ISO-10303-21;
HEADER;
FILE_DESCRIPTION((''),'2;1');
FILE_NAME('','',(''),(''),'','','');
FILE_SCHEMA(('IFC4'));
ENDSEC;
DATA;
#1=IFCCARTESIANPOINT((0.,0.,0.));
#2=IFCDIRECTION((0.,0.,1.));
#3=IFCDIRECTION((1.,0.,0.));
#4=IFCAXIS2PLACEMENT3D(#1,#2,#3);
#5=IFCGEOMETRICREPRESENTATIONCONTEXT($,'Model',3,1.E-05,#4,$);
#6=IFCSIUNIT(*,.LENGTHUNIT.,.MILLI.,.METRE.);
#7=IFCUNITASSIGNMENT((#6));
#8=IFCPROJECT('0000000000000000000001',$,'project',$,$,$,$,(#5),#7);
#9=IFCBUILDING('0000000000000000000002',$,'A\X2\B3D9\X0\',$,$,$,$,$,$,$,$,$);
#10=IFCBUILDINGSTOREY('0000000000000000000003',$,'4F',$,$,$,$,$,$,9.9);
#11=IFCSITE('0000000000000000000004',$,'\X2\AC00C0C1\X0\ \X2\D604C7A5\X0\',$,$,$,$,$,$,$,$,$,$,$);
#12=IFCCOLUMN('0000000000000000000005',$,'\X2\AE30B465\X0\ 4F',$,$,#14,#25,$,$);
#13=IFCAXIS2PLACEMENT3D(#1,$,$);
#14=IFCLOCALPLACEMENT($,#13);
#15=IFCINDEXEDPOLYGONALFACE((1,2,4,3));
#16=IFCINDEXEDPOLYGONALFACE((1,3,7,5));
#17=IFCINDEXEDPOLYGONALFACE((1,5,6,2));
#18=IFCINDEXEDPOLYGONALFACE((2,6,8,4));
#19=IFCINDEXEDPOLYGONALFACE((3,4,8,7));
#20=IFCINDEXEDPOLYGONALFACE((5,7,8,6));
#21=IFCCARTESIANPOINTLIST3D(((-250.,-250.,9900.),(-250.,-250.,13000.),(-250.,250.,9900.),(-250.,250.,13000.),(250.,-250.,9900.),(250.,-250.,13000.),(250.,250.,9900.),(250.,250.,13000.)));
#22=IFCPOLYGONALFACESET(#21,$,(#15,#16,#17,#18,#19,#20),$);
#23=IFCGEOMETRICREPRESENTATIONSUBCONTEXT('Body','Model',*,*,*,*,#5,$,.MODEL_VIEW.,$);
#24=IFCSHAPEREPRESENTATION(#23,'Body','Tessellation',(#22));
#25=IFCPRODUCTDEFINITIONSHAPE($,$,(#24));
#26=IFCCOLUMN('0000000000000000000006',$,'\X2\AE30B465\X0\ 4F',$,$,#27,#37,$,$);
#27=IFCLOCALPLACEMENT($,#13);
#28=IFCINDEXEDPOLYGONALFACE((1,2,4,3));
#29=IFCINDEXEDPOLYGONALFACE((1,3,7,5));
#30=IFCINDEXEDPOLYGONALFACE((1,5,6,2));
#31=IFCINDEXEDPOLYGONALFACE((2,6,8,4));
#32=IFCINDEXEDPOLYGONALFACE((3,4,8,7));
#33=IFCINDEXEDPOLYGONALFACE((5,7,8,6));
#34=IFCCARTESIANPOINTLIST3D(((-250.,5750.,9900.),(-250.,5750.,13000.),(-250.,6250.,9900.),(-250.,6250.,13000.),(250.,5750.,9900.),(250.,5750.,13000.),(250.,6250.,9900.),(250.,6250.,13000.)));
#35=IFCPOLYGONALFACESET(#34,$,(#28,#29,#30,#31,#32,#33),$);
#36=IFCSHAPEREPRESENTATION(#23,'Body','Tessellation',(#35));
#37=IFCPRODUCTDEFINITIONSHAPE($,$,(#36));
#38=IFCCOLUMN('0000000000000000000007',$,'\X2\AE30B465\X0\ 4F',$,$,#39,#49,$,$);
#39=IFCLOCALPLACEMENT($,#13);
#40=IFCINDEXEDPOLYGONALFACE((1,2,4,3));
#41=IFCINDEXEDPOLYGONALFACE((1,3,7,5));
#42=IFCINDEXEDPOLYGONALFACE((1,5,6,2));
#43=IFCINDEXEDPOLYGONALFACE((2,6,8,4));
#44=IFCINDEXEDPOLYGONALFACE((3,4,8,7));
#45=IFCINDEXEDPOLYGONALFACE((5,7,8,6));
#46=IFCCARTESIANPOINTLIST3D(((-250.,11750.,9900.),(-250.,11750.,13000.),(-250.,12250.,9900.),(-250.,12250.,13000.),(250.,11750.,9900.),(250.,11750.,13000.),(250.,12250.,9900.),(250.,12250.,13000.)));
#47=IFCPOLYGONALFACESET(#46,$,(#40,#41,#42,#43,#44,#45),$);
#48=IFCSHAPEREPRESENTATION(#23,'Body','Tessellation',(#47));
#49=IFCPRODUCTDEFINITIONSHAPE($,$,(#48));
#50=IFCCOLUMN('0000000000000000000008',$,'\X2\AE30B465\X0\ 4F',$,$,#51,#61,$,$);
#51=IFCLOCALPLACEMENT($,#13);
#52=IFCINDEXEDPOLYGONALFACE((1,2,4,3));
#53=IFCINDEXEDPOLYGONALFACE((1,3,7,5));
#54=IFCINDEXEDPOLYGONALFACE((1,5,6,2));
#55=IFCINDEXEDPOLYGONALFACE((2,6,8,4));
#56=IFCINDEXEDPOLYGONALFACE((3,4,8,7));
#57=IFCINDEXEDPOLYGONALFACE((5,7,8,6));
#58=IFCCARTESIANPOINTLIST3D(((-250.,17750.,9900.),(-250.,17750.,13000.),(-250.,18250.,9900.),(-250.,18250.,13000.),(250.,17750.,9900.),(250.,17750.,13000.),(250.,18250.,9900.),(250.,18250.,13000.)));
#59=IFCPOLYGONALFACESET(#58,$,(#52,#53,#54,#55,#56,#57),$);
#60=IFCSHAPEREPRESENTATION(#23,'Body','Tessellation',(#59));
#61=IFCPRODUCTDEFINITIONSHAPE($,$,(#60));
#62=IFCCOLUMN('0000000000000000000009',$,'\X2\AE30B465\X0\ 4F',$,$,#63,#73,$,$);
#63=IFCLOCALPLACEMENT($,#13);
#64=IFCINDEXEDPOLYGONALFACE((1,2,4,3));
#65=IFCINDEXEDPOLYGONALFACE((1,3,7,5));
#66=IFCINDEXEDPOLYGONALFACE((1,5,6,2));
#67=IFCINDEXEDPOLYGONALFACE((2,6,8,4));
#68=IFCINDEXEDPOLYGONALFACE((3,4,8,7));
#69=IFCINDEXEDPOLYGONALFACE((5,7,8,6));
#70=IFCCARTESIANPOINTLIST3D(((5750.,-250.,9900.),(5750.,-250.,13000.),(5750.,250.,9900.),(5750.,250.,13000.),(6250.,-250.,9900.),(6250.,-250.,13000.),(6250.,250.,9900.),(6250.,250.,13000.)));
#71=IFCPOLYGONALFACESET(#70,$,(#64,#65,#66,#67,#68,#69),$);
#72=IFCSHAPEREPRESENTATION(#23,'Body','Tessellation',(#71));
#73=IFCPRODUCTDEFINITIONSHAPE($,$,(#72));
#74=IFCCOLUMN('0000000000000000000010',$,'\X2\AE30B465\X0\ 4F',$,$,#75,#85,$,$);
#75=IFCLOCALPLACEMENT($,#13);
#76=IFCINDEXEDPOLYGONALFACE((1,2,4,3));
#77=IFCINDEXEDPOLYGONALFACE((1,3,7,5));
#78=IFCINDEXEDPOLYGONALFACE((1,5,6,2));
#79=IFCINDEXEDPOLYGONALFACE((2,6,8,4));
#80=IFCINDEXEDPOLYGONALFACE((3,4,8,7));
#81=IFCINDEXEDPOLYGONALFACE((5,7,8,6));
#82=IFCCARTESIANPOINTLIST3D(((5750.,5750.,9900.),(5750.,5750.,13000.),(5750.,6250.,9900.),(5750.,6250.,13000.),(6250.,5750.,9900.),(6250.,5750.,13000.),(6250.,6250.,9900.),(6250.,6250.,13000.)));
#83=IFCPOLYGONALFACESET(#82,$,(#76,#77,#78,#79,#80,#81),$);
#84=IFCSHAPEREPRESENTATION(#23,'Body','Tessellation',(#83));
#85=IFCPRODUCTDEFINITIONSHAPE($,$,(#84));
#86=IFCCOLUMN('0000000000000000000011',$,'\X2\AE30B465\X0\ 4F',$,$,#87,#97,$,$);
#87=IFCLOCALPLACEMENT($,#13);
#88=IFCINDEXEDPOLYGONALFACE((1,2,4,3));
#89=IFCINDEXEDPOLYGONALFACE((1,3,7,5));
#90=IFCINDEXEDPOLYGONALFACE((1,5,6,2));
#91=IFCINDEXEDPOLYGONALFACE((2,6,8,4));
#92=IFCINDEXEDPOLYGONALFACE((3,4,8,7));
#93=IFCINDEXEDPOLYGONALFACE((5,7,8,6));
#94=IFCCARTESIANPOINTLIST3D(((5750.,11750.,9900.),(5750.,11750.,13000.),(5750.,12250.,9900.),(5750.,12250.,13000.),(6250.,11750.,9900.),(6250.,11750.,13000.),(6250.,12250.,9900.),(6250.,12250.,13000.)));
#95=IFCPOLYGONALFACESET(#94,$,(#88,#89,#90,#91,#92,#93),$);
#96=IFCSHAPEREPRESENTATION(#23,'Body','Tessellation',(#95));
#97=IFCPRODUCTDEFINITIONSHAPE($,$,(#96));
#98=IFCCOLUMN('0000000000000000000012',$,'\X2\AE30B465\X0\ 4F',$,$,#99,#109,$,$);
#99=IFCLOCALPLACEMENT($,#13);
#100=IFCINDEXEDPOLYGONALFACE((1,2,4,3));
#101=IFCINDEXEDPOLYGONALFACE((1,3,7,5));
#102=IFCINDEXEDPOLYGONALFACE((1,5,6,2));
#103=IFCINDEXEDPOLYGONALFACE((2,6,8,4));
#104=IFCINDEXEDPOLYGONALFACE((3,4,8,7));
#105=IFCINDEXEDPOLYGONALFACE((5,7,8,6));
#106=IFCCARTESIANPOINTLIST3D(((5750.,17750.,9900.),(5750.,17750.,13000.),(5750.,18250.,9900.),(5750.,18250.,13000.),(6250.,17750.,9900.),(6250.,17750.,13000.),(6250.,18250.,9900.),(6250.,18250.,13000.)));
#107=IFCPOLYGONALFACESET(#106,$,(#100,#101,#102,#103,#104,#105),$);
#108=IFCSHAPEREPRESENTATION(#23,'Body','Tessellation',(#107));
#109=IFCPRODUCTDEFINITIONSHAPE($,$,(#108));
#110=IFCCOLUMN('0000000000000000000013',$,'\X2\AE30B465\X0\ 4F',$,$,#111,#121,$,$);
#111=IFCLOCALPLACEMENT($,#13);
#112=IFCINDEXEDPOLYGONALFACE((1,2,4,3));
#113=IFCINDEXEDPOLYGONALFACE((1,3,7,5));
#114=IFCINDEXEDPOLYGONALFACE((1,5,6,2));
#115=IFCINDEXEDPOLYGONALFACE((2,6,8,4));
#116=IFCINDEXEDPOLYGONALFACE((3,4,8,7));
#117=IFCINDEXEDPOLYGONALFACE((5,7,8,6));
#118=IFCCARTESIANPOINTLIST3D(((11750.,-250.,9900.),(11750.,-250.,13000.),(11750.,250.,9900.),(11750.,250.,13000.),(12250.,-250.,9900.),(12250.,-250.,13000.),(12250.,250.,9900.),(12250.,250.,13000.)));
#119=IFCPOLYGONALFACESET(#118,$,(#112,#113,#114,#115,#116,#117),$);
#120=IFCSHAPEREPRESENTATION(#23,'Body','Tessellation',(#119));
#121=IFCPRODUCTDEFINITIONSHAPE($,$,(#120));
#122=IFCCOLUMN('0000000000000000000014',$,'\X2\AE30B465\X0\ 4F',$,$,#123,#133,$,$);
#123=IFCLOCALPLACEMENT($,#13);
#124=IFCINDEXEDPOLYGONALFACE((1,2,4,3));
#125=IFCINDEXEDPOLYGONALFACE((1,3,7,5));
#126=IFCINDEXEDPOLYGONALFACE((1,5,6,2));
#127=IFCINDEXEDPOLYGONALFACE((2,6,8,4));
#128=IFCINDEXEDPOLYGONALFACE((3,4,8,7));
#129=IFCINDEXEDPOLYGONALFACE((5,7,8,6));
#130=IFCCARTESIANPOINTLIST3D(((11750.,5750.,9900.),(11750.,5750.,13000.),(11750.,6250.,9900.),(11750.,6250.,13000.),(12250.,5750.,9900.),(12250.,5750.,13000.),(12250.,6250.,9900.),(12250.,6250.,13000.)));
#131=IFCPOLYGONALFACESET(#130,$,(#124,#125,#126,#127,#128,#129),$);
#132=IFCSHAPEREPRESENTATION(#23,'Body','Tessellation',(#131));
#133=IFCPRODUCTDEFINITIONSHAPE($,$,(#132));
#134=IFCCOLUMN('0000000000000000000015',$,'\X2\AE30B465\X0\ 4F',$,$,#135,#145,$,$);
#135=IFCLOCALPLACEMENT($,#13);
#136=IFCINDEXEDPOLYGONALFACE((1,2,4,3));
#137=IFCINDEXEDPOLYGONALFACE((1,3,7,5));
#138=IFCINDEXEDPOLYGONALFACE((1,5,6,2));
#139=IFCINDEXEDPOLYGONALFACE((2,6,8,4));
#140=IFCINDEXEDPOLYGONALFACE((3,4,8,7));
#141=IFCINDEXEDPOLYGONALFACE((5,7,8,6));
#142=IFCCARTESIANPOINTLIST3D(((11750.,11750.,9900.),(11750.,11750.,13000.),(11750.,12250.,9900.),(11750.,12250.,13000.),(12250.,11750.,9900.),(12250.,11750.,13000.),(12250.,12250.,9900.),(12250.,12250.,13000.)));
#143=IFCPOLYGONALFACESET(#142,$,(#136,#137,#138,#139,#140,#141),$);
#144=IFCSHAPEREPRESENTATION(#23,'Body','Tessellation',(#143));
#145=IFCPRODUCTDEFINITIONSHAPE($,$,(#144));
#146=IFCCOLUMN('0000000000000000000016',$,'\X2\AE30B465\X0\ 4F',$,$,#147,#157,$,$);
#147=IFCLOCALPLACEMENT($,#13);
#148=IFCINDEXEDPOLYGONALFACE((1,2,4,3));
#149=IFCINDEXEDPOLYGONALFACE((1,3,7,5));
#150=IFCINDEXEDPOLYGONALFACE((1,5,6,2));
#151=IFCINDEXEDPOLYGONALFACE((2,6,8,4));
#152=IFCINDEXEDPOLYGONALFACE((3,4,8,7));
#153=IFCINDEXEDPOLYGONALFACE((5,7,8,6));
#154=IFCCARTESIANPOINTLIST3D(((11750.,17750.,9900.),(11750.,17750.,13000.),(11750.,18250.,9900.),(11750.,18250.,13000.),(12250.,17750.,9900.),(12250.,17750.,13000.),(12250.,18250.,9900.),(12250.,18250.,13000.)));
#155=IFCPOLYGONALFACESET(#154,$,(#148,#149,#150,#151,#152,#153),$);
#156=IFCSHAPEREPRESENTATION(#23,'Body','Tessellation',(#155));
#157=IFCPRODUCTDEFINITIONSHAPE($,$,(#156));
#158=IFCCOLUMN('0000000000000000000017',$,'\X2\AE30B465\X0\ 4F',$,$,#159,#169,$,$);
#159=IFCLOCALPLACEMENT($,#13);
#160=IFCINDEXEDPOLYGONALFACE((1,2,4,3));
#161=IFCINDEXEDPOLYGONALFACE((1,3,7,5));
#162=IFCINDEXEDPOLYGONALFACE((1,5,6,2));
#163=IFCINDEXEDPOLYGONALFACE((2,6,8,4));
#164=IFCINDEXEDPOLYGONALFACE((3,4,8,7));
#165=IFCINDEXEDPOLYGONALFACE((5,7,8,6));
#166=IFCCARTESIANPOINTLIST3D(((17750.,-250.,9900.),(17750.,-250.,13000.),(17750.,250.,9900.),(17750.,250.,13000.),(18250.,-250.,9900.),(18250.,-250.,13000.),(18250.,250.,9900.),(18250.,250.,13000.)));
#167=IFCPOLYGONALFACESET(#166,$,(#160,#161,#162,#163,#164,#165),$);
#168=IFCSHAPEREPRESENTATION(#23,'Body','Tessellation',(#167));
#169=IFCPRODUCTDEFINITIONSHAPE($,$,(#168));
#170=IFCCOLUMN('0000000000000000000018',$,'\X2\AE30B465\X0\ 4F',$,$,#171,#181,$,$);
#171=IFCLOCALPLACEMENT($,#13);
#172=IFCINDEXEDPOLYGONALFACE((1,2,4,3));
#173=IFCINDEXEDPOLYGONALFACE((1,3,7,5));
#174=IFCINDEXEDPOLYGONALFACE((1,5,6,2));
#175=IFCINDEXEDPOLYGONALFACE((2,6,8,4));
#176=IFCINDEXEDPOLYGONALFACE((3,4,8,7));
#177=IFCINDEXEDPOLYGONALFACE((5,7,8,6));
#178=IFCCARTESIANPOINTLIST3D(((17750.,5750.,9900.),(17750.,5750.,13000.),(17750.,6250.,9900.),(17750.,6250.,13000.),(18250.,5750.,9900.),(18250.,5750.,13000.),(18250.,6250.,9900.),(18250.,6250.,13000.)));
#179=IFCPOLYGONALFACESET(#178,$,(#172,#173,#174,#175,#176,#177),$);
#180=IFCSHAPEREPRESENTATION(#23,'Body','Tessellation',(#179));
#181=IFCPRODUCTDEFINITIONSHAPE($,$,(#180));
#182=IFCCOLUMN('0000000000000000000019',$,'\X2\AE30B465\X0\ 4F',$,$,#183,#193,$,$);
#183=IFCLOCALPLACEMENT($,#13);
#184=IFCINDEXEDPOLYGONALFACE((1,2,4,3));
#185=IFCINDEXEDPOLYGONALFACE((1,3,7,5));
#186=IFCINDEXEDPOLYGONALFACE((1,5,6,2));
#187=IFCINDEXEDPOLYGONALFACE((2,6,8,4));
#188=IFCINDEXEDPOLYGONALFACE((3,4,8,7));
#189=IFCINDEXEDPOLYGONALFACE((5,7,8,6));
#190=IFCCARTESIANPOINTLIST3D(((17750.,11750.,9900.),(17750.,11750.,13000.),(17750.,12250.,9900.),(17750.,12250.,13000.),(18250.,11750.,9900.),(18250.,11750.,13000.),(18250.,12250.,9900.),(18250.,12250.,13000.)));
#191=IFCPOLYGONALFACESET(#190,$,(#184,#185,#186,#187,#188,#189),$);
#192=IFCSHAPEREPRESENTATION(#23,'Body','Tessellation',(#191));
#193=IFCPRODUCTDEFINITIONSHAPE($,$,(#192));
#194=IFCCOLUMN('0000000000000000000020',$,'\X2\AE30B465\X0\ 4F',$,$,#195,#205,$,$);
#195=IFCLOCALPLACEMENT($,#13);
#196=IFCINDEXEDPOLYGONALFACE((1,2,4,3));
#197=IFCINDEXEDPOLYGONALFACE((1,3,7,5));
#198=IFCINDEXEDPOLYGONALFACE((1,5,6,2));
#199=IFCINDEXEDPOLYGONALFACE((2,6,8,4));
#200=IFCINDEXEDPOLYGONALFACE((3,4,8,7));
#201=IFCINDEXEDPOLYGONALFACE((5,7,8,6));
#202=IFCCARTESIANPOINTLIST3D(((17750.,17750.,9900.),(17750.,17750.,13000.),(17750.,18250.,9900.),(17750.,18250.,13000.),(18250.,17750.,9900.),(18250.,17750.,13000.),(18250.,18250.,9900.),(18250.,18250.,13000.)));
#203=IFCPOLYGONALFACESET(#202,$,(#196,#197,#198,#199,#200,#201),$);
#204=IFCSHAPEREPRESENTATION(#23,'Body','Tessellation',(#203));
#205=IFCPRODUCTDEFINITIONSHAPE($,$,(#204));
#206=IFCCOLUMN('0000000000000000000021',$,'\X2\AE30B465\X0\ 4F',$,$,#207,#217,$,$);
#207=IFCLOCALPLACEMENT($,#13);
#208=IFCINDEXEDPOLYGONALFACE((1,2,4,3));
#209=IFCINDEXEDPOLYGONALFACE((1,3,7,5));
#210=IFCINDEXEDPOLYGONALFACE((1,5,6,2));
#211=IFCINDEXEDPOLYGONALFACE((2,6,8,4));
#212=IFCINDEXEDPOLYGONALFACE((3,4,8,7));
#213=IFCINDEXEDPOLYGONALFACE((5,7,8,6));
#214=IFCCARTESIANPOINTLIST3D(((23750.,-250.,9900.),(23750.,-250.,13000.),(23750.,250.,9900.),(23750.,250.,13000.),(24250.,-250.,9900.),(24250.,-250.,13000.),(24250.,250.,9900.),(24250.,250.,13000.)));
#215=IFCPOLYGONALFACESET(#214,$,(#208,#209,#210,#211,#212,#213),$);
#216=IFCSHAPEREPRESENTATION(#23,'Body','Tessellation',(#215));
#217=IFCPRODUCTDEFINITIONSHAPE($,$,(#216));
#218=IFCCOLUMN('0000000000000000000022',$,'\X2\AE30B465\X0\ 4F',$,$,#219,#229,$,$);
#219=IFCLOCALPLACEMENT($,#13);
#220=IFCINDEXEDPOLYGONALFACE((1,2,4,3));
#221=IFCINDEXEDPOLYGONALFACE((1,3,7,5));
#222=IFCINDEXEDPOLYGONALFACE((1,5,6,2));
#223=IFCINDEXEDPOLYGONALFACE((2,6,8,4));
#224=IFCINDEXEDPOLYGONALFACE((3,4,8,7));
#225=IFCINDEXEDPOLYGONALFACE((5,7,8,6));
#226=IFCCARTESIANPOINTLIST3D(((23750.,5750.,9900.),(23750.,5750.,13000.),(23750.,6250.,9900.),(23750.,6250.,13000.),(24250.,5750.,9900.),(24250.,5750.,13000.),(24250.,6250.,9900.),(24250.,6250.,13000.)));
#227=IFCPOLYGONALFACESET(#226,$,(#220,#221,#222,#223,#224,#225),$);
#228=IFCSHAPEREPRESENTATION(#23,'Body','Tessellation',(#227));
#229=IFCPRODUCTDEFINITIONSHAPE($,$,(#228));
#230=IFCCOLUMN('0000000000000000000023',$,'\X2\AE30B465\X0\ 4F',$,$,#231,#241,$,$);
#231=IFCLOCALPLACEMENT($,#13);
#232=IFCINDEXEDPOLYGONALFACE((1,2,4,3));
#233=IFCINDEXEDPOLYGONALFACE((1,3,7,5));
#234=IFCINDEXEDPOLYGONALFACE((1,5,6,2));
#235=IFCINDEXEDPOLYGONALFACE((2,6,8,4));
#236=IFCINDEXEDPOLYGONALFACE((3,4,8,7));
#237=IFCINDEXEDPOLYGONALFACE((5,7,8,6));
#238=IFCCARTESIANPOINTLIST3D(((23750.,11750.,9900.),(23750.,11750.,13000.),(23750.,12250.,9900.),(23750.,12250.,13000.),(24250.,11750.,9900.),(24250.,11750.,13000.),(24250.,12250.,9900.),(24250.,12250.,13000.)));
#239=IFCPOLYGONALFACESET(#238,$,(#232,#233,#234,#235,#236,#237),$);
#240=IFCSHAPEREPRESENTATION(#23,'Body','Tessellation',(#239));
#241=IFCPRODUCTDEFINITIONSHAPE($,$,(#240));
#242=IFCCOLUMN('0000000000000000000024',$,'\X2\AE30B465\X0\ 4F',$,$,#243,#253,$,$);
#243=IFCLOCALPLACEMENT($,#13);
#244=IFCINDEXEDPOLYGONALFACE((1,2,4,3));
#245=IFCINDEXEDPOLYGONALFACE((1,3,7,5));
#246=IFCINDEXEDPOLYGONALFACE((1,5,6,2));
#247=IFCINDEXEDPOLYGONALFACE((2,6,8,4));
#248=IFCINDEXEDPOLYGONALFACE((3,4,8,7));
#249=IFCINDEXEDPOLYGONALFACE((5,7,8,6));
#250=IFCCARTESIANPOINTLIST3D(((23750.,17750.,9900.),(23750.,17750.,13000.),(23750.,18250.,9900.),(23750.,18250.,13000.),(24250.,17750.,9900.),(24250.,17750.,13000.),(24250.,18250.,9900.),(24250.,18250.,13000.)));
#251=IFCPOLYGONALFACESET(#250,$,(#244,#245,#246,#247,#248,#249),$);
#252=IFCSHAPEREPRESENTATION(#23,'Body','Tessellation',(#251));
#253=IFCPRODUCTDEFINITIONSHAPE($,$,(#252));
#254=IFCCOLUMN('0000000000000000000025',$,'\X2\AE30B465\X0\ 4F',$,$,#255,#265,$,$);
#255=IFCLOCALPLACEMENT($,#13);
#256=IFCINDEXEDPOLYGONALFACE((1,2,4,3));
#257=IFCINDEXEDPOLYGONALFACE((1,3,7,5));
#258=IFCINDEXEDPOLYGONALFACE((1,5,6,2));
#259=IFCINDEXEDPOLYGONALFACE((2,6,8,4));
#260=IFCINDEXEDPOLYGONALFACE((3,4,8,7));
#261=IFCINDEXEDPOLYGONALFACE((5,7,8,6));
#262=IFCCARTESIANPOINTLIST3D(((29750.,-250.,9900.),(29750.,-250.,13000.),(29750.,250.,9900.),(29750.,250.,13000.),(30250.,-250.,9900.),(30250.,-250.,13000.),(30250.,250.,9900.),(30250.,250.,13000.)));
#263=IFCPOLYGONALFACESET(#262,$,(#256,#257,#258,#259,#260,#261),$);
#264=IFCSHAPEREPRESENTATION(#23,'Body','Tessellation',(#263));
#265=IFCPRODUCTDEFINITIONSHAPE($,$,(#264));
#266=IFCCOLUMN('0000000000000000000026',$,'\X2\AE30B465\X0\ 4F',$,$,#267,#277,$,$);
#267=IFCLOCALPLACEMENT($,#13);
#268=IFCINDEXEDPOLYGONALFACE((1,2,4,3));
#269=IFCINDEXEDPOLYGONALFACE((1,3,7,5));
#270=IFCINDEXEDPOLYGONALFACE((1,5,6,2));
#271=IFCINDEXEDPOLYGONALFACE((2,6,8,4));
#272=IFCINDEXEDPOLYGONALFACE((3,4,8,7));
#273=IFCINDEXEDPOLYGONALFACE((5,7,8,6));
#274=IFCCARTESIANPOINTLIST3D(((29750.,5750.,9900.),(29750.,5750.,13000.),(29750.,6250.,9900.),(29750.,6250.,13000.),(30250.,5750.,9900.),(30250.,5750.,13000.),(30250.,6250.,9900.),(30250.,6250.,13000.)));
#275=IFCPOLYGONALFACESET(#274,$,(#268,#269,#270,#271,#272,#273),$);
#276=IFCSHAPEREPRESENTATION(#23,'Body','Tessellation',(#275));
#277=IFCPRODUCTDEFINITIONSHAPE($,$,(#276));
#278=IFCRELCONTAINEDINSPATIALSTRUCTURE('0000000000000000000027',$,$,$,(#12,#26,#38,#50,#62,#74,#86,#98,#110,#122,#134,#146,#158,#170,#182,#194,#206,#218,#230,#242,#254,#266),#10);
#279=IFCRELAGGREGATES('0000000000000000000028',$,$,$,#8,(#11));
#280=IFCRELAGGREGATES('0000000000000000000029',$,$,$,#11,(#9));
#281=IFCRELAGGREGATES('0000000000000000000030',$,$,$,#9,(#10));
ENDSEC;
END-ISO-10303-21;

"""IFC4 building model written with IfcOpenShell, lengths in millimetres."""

from ifc_helpers import new_model, si_unit, frame, origin_with_axes, place, context, subcontext, project, spatial, indexed_curve, outline, extrude, element, save


model = new_model("IFC4")

# Units and contexts
model_context = context("Model", 3, precision=1e-05, world=origin_with_axes())
body_context = subcontext(model_context, "Body", "Model", "MODEL_VIEW")
ifc_project = project(units=[si_unit("LENGTHUNIT", "METRE", prefix="MILLI")], contexts=[model_context])

# Site, building, storey
site = spatial("IfcSite", under=ifc_project, Name="가상 현장")
building = spatial("IfcBuilding", under=site, Name="A동")
storey = spatial("IfcBuildingStorey", under=building, Name="4F", Elevation=9.9)

# Columns
for number, where, z_axis, x_axis, name in (
    (1, (-250.0, -250.0, 9900.0), (0.0, 0.0, 1.0), (1.0, 0.0, 0.0), "기둥 4F"),
    (2, (-250.0, 5750.0, 9900.0), (0.0, 0.0, 1.0), (1.0, 0.0, 0.0), "기둥 4F"),
    (3, (-250.0, 11750.0, 9900.0), (0.0, 0.0, 1.0), (1.0, 0.0, 0.0), "기둥 4F"),
    (4, (-250.0, 17750.0, 9900.0), (0.0, 0.0, 1.0), (1.0, 0.0, 0.0), "기둥 4F"),
    (5, (5750.0, -250.0, 9900.0), (0.0, 0.0, 1.0), (1.0, 0.0, 0.0), "기둥 4F"),
    (6, (5750.0, 5750.0, 9900.0), (0.0, 0.0, 1.0), (1.0, 0.0, 0.0), "기둥 4F"),
    (7, (5750.0, 11750.0, 9900.0), (0.0, 0.0, 1.0), (1.0, 0.0, 0.0), "기둥 4F"),
    (8, (5750.0, 17750.0, 9900.0), (0.0, 0.0, 1.0), (1.0, 0.0, 0.0), "기둥 4F"),
    (9, (11750.0, -250.0, 9900.0), (0.0, 0.0, 1.0), (1.0, 0.0, 0.0), "기둥 4F"),
    (10, (11750.0, 5750.0, 9900.0), (0.0, 0.0, 1.0), (1.0, 0.0, 0.0), "기둥 4F"),
    (11, (11750.0, 11750.0, 9900.0), (0.0, 0.0, 1.0), (1.0, 0.0, 0.0), "기둥 4F"),
    (12, (11750.0, 17750.0, 9900.0), (0.0, 0.0, 1.0), (1.0, 0.0, 0.0), "기둥 4F"),
    (13, (17750.0, -250.0, 9900.0), (0.0, 0.0, 1.0), (1.0, 0.0, 0.0), "기둥 4F"),
    (14, (17750.0, 5750.0, 9900.0), (0.0, 0.0, 1.0), (1.0, 0.0, 0.0), "기둥 4F"),
    (15, (17750.0, 11750.0, 9900.0), (0.0, 0.0, 1.0), (1.0, 0.0, 0.0), "기둥 4F"),
    (16, (17750.0, 17750.0, 9900.0), (0.0, 0.0, 1.0), (1.0, 0.0, 0.0), "기둥 4F"),
    (17, (23750.0, -250.0, 9900.0), (0.0, 0.0, 1.0), (1.0, 0.0, 0.0), "기둥 4F"),
    (18, (23750.0, 5750.0, 9900.0), (0.0, 0.0, 1.0), (1.0, 0.0, 0.0), "기둥 4F"),
    (19, (23750.0, 11750.0, 9900.0), (0.0, 0.0, 1.0), (1.0, 0.0, 0.0), "기둥 4F"),
    (20, (23750.0, 17750.0, 9900.0), (0.0, 0.0, 1.0), (1.0, 0.0, 0.0), "기둥 4F"),
    (21, (29750.0, -250.0, 9900.0), (0.0, 0.0, 1.0), (1.0, 0.0, 0.0), "기둥 4F"),
    (22, (29750.0, 5750.0, 9900.0), (0.0, 0.0, 1.0), (1.0, 0.0, 0.0), "기둥 4F"),
):
    element("IfcColumn", number, at=place(None, frame(where, z_axis=z_axis, x_axis=x_axis)), inside=storey, Name=name, context=body_context, shape_type="SweptSolid", body=[
        extrude(outline(indexed_curve([(0.0, 0.0), (0.0, 500.0), (500.0, 500.0), (500.0, 0.0), (0.0, 0.0)], self_intersect=False)), origin_with_axes(), (0.0, 0.0, 1.0), 3100.0),
    ])

save(model, "model.ifc")
